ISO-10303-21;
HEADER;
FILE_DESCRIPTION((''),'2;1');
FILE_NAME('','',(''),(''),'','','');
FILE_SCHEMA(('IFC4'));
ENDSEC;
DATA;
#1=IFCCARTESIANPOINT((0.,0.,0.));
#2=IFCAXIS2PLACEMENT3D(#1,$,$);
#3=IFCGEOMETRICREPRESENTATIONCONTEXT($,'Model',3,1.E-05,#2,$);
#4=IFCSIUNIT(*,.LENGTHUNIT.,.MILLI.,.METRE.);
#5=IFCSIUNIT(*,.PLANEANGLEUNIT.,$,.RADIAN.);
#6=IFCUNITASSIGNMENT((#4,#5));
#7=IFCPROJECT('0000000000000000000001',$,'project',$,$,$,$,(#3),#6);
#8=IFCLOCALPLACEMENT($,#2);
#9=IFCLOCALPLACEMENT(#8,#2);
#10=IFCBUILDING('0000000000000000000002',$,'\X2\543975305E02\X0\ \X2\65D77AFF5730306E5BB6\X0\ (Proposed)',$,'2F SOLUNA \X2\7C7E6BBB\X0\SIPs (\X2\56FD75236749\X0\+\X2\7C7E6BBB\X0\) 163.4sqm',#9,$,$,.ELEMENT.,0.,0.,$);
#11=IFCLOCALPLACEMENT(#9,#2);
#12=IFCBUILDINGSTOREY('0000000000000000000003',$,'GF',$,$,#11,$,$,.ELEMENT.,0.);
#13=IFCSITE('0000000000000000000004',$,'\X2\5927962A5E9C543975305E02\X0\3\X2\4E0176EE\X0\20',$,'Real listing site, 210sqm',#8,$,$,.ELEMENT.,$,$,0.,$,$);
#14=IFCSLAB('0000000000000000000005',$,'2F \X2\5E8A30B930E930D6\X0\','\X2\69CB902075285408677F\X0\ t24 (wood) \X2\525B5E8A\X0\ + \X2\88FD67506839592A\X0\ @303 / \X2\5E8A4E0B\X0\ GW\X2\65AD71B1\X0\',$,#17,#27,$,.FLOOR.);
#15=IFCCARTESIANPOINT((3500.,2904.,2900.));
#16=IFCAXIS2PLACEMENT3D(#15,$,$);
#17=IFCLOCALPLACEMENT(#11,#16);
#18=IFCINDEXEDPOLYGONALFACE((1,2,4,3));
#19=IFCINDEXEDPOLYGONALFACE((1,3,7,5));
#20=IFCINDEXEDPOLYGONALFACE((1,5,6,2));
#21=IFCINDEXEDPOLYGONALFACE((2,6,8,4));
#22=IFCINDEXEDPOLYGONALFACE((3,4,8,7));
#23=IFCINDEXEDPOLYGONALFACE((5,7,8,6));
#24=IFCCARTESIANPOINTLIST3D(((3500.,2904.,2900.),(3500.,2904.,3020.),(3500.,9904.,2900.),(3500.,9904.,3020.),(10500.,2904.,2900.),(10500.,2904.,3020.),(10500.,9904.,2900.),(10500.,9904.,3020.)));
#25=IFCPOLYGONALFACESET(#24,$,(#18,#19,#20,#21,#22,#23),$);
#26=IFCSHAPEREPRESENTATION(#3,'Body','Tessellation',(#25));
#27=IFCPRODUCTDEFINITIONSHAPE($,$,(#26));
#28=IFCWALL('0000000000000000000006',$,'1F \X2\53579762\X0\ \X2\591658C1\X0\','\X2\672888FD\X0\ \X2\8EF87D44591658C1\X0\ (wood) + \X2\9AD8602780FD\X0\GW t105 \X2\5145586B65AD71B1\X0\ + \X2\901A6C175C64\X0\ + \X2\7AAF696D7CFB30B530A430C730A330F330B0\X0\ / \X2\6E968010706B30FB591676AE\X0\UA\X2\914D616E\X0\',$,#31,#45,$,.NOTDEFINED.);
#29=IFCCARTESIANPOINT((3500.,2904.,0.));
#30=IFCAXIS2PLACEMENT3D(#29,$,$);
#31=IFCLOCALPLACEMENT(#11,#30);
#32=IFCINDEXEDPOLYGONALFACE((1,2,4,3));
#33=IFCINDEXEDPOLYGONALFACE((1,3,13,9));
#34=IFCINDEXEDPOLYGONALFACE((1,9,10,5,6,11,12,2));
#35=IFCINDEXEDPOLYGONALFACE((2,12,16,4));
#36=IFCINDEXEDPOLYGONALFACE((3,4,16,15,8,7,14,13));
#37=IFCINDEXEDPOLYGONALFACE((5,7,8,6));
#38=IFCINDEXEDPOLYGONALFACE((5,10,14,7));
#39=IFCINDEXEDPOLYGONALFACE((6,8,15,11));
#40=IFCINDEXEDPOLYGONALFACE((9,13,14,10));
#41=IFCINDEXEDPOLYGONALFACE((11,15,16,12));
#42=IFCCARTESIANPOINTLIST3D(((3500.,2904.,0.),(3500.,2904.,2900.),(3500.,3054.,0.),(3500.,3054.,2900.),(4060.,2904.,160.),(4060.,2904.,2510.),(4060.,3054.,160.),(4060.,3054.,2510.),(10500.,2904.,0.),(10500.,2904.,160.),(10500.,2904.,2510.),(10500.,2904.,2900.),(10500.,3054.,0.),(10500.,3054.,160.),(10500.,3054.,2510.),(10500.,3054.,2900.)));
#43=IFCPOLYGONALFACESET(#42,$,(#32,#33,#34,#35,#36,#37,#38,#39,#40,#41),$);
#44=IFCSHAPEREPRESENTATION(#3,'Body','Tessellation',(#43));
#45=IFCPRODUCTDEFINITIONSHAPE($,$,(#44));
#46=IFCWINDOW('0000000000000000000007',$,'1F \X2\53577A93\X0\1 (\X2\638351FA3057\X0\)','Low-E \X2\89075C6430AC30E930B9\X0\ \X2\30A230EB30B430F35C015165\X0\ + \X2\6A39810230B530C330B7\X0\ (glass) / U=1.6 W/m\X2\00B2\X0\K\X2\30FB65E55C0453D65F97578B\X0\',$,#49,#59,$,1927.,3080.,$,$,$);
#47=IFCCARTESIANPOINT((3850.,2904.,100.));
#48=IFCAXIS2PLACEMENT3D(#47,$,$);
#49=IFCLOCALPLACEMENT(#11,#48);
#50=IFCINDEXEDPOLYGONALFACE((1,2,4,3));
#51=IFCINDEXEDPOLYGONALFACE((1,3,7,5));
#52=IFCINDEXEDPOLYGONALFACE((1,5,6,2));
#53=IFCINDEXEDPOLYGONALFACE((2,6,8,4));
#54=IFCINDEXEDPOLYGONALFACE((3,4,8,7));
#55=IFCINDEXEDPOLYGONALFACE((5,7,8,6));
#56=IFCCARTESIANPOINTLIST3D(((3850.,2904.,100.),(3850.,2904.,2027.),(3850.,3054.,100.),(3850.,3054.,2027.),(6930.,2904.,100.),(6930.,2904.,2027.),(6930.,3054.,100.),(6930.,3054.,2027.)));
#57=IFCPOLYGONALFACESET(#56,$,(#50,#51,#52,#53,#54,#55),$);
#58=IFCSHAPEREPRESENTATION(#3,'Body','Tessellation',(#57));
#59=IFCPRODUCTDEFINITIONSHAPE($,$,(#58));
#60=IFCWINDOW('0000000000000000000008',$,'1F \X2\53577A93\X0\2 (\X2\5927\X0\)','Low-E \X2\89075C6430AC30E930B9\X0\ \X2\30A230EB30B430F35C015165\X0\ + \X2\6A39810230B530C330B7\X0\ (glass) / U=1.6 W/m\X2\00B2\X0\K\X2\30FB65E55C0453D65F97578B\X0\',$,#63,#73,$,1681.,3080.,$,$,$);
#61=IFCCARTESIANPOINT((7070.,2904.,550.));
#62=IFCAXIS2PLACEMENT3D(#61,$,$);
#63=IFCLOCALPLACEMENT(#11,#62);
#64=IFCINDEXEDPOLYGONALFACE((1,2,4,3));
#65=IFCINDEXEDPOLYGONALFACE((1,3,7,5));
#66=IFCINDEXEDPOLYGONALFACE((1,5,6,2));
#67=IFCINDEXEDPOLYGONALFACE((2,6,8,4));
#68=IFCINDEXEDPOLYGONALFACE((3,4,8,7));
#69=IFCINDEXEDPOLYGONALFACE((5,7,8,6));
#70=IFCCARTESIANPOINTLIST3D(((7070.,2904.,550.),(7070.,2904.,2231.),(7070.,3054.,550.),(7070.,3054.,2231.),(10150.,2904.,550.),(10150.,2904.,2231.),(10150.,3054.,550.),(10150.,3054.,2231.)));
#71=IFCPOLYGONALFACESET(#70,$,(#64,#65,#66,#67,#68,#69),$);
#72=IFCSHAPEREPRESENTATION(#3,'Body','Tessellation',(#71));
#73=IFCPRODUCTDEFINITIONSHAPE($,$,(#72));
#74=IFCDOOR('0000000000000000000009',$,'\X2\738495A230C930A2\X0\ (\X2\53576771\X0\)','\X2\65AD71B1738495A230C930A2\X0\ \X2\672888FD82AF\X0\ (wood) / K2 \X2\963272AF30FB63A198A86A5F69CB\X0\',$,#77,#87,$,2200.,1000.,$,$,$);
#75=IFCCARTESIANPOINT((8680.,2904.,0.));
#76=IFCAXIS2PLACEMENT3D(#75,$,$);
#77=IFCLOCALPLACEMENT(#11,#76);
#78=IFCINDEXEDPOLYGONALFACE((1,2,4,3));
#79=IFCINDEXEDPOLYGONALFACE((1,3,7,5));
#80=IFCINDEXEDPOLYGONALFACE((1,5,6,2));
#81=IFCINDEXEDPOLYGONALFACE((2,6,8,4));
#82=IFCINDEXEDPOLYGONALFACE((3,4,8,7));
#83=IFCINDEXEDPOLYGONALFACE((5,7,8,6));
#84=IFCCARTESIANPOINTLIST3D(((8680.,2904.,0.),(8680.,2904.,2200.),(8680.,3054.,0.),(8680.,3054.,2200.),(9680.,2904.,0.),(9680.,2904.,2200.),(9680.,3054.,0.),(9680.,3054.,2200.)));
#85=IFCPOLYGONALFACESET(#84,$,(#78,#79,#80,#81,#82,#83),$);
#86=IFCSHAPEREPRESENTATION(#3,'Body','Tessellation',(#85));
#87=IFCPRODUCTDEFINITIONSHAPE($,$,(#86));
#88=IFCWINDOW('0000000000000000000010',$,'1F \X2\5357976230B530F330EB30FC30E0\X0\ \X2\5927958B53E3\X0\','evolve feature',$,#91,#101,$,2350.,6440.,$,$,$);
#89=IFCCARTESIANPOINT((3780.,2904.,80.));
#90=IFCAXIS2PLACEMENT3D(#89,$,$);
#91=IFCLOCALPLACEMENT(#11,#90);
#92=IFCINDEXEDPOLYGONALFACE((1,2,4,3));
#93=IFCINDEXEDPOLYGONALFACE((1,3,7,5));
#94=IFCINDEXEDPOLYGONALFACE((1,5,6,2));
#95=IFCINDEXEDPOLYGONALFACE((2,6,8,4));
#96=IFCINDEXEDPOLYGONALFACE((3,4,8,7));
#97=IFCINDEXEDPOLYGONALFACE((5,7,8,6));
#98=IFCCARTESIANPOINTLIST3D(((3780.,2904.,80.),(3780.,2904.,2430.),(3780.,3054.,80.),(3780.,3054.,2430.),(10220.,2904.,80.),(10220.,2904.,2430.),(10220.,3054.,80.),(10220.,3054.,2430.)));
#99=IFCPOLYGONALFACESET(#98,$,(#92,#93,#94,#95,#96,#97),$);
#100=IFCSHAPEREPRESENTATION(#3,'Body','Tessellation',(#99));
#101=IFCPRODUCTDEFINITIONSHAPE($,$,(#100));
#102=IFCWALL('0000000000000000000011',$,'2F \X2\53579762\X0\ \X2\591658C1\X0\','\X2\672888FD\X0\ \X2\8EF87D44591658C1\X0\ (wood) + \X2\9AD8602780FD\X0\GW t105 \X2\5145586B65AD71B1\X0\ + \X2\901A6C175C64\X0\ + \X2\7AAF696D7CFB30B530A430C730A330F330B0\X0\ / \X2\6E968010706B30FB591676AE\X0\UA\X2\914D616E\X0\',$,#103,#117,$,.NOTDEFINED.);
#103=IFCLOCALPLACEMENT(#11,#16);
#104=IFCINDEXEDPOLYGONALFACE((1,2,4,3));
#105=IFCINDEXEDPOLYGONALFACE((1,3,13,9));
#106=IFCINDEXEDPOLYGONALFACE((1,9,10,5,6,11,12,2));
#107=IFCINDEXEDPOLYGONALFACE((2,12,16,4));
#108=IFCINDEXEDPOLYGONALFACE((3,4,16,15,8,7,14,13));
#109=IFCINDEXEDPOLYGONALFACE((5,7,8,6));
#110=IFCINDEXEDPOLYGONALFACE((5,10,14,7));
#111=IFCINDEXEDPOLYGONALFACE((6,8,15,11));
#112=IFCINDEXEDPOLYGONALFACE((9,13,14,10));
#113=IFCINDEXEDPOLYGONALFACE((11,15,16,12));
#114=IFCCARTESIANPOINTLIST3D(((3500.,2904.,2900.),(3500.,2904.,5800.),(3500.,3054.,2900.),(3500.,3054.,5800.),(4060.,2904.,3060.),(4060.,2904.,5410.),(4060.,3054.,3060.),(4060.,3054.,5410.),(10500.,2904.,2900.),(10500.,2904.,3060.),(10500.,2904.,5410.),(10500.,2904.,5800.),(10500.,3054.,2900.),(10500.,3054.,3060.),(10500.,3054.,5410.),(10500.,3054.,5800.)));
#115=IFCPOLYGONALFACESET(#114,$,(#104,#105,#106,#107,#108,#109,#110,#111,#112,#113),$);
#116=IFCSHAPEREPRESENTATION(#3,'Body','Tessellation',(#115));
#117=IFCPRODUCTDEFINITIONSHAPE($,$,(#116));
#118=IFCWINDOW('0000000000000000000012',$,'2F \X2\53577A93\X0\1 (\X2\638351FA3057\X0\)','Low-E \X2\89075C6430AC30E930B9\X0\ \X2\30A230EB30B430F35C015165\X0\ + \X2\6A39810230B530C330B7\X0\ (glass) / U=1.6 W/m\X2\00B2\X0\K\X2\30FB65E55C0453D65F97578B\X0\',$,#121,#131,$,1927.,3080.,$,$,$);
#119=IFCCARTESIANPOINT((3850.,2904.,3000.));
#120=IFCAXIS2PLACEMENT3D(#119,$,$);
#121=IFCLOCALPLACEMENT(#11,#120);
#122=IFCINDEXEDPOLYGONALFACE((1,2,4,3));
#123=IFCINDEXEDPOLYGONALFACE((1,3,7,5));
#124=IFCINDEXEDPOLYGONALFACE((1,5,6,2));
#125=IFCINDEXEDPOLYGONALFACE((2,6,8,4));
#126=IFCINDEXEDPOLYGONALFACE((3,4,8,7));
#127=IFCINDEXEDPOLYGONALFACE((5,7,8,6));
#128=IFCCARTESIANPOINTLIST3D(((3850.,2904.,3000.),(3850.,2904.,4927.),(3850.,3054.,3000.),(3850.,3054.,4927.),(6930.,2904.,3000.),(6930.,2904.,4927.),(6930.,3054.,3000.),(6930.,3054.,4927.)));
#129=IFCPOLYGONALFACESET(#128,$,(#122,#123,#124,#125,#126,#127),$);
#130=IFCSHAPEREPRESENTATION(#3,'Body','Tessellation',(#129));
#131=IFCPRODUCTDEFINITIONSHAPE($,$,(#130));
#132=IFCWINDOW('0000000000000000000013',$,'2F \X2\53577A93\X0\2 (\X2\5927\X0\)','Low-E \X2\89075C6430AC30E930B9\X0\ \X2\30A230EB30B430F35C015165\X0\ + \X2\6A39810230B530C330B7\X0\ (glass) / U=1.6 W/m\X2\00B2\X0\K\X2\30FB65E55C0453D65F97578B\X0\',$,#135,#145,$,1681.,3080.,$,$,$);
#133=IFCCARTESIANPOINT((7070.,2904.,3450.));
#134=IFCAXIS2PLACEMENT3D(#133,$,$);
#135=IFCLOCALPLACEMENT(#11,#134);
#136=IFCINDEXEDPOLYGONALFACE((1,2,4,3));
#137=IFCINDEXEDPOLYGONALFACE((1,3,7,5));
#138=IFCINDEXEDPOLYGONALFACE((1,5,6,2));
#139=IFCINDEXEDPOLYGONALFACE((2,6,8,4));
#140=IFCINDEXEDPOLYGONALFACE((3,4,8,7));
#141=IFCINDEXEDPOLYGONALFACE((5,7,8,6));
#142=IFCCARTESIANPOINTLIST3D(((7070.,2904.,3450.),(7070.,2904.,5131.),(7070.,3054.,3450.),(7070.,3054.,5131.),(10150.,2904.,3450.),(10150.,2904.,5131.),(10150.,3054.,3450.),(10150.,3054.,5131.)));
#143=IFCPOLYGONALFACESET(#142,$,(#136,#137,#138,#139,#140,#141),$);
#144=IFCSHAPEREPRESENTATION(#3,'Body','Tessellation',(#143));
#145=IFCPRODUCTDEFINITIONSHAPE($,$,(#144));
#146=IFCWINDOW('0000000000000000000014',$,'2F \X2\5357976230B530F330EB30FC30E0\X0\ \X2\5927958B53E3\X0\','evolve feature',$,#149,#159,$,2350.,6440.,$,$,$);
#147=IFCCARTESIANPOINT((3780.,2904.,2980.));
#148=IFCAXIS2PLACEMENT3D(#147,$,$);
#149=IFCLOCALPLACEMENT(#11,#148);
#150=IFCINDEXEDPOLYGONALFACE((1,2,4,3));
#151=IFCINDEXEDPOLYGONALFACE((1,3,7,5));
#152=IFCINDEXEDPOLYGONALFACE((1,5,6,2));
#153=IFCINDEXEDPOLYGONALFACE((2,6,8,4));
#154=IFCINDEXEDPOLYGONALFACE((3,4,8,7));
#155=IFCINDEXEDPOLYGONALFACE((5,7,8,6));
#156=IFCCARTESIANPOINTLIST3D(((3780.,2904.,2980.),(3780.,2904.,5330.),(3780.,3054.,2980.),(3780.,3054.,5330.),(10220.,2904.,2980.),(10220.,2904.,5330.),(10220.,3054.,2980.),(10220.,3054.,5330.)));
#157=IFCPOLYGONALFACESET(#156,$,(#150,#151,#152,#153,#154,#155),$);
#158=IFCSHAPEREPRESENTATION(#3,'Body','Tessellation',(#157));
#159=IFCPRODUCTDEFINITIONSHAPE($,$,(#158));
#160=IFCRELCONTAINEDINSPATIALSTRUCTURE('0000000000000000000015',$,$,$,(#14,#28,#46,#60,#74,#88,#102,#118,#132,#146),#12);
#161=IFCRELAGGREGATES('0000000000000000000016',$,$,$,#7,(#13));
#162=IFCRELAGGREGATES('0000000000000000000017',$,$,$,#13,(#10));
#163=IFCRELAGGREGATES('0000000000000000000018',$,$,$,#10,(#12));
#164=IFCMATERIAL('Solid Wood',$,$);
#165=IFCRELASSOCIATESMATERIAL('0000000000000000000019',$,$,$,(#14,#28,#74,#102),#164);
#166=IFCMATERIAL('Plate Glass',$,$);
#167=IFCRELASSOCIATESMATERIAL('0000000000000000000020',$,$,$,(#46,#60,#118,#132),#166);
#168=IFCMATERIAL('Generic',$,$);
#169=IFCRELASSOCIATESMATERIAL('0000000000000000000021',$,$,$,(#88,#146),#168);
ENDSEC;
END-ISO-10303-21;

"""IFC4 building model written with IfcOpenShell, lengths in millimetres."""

from ifc_helpers import new_model, si_unit, frame, frame_2d, origin, place, context, project, spatial, rectangle, extrude, material, element, fill, save


model = new_model("IFC4")

# Units and contexts
model_context = context("Model", 3, precision=1e-05, world=origin())
ifc_project = project(units=[si_unit("LENGTHUNIT", "METRE", prefix="MILLI"), si_unit("PLANEANGLEUNIT", "RADIAN")], contexts=[model_context])

# Site, building, storey
site_placement = place(None, origin())
site = spatial("IfcSite", under=ifc_project, at=site_placement, Name="大阪府吹田市3丁目20", ObjectType="Real listing site, 210sqm", CompositionType="ELEMENT", RefElevation=0.0)
building_placement = place(site_placement, origin())
building = spatial("IfcBuilding", under=site, at=building_placement, Name="吹田市 旗竿地の家 (Proposed)", ObjectType="2F SOLUNA 籾殻SIPs (国産杉+籾殻) 163.4sqm", CompositionType="ELEMENT", ElevationOfRefHeight=0.0, ElevationOfTerrain=0.0)
storey_placement = place(building_placement, origin())
storey = spatial("IfcBuildingStorey", under=building, at=storey_placement, Name="GF", CompositionType="ELEMENT", Elevation=0.0)

# Slab
ifc_material_1 = material(Name="Solid Wood")
slab_1_placement = place(storey_placement, frame((3500.0, 2904.0, 2900.0)))
element("IfcSlab", 1, at=slab_1_placement, inside=storey, material=ifc_material_1, Name="2F 床スラブ", Description="構造用合板 t24 (wood) 剛床 + 製材根太 @303 / 床下 GW断熱", PredefinedType="FLOOR", context=model_context, shape_type="SweptSolid", body=[
    extrude(rectangle(XDim=7000.0, YDim=7000.0, at=frame_2d((3500.0, 3500.0))), frame((3500.0, 2904.0, 2900.0)), (0.0, 0.0, 1.0), 120.0),
])
ifc_material_2 = material(Name="Generic")

# Wall, openings, windows, door
wall_1_placement = place(storey_placement, frame((3500.0, 2904.0, 0.0)))
wall_1 = element("IfcWall", 2, at=wall_1_placement, inside=storey, material=ifc_material_1, Name="1F 南面 外壁", Description="木製 軸組外壁 (wood) + 高性能GW t105 充填断熱 + 通気層 + 窯業系サイディング / 準耐火・外皮UA配慮", PredefinedType="NOTDEFINED", context=model_context, shape_type="SweptSolid", body=[
    extrude(rectangle(XDim=7000.0, YDim=150.0, at=frame_2d((3500.0, 75.0))), frame((3500.0, 2904.0, 0.0)), (0.0, 0.0, 1.0), 2900.0),
])
opening_1_placement = place(storey_placement, frame((3850.0, 2904.0, 100.0)))
opening_1 = element("IfcOpeningElement", 3, at=opening_1_placement, cuts=wall_1, PredefinedType="NOTDEFINED", context=model_context, shape_type="SweptSolid", body=[
    extrude(rectangle(XDim=3080.0, YDim=150.0, at=frame_2d((1540.0, 75.0))), frame((3850.0, 2904.0, 100.0)), (0.0, 0.0, 1.0), 1927.0),
])
opening_2_placement = place(storey_placement, frame((7070.0, 2904.0, 550.0)))
opening_2 = element("IfcOpeningElement", 4, at=opening_2_placement, cuts=wall_1, PredefinedType="NOTDEFINED", context=model_context, shape_type="SweptSolid", body=[
    extrude(rectangle(XDim=3080.0, YDim=150.0, at=frame_2d((1540.0, 75.0))), frame((7070.0, 2904.0, 550.0)), (0.0, 0.0, 1.0), 1681.0),
])
opening_3_placement = place(storey_placement, frame((8680.0, 2904.0, 0.0)))
opening_3 = element("IfcOpeningElement", 5, at=opening_3_placement, cuts=wall_1, PredefinedType="NOTDEFINED", context=model_context, shape_type="SweptSolid", body=[
    extrude(rectangle(XDim=1000.0, YDim=150.0, at=frame_2d((500.0, 75.0))), frame((8680.0, 2904.0, 0.0)), (0.0, 0.0, 1.0), 2200.0),
])
opening_4_placement = place(storey_placement, frame((3780.0, 2904.0, 80.0)))
opening_4 = element("IfcOpeningElement", 6, at=opening_4_placement, cuts=wall_1, PredefinedType="NOTDEFINED", context=model_context, shape_type="SweptSolid", body=[
    extrude(rectangle(XDim=6440.0, YDim=150.0, at=frame_2d((3220.0, 75.0))), frame((3780.0, 2904.0, 80.0)), (0.0, 0.0, 1.0), 2350.0),
])
ifc_material_3 = material(Name="Plate Glass")
window_1_placement = place(storey_placement, frame((3850.0, 2904.0, 100.0)))
window_1 = element("IfcWindow", 7, at=window_1_placement, inside=storey, material=ifc_material_3, Name="1F 南窓1 (掃出し)", Description="Low-E 複層ガラス アルゴン封入 + 樹脂サッシ (glass) / U=1.6 W/m²K・日射取得型", OverallHeight=1927.0, OverallWidth=3080.0, context=model_context, shape_type="SweptSolid", body=[
    extrude(rectangle(XDim=3080.0, YDim=150.0, at=frame_2d((1540.0, 75.0))), frame((3850.0, 2904.0, 100.0)), (0.0, 0.0, 1.0), 1927.0),
])
fill(opening_1, window_1)
window_2_placement = place(storey_placement, frame((7070.0, 2904.0, 550.0)))
window_2 = element("IfcWindow", 8, at=window_2_placement, inside=storey, material=ifc_material_3, Name="1F 南窓2 (大)", Description="Low-E 複層ガラス アルゴン封入 + 樹脂サッシ (glass) / U=1.6 W/m²K・日射取得型", OverallHeight=1681.0, OverallWidth=3080.0, context=model_context, shape_type="SweptSolid", body=[
    extrude(rectangle(XDim=3080.0, YDim=150.0, at=frame_2d((1540.0, 75.0))), frame((7070.0, 2904.0, 550.0)), (0.0, 0.0, 1.0), 1681.0),
])
fill(opening_2, window_2)
door_placement = place(storey_placement, frame((8680.0, 2904.0, 0.0)))
door = element("IfcDoor", 9, at=door_placement, inside=storey, material=ifc_material_1, Name="玄関ドア (南東)", Description="断熱玄関ドア 木製芯 (wood) / K2 防犯・採風機構", OverallHeight=2200.0, OverallWidth=1000.0, context=model_context, shape_type="SweptSolid", body=[
    extrude(rectangle(XDim=1000.0, YDim=150.0, at=frame_2d((500.0, 75.0))), frame((8680.0, 2904.0, 0.0)), (0.0, 0.0, 1.0), 2200.0),
])
fill(opening_3, door)
window_3_placement = place(storey_placement, frame((3780.0, 2904.0, 80.0)))
window_3 = element("IfcWindow", 10, at=window_3_placement, inside=storey, material=ifc_material_2, Name="1F 南面サンルーム 大開口", Description="evolve feature", OverallHeight=2350.0, OverallWidth=6440.0, context=model_context, shape_type="SweptSolid", body=[
    extrude(rectangle(XDim=6440.0, YDim=150.0, at=frame_2d((3220.0, 75.0))), frame((3780.0, 2904.0, 80.0)), (0.0, 0.0, 1.0), 2350.0),
])
fill(opening_4, window_3)

# Wall, openings, windows
wall_2_placement = place(storey_placement, frame((3500.0, 2904.0, 2900.0)))
wall_2 = element("IfcWall", 11, at=wall_2_placement, inside=storey, material=ifc_material_1, Name="2F 南面 外壁", Description="木製 軸組外壁 (wood) + 高性能GW t105 充填断熱 + 通気層 + 窯業系サイディング / 準耐火・外皮UA配慮", PredefinedType="NOTDEFINED", context=model_context, shape_type="SweptSolid", body=[
    extrude(rectangle(XDim=7000.0, YDim=150.0, at=frame_2d((3500.0, 75.0))), frame((3500.0, 2904.0, 2900.0)), (0.0, 0.0, 1.0), 2900.0),
])
opening_5_placement = place(storey_placement, frame((3850.0, 2904.0, 3000.0)))
opening_5 = element("IfcOpeningElement", 12, at=opening_5_placement, cuts=wall_2, PredefinedType="NOTDEFINED", context=model_context, shape_type="SweptSolid", body=[
    extrude(rectangle(XDim=3080.0, YDim=150.0, at=frame_2d((1540.0, 75.0))), frame((3850.0, 2904.0, 3000.0)), (0.0, 0.0, 1.0), 1927.0),
])
opening_6_placement = place(storey_placement, frame((7070.0, 2904.0, 3450.0)))
opening_6 = element("IfcOpeningElement", 13, at=opening_6_placement, cuts=wall_2, PredefinedType="NOTDEFINED", context=model_context, shape_type="SweptSolid", body=[
    extrude(rectangle(XDim=3080.0, YDim=150.0, at=frame_2d((1540.0, 75.0))), frame((7070.0, 2904.0, 3450.0)), (0.0, 0.0, 1.0), 1681.0),
])
opening_7_placement = place(storey_placement, frame((3780.0, 2904.0, 2980.0)))
opening_7 = element("IfcOpeningElement", 14, at=opening_7_placement, cuts=wall_2, PredefinedType="NOTDEFINED", context=model_context, shape_type="SweptSolid", body=[
    extrude(rectangle(XDim=6440.0, YDim=150.0, at=frame_2d((3220.0, 75.0))), frame((3780.0, 2904.0, 2980.0)), (0.0, 0.0, 1.0), 2350.0),
])
window_4_placement = place(storey_placement, frame((3850.0, 2904.0, 3000.0)))
window_4 = element("IfcWindow", 15, at=window_4_placement, inside=storey, material=ifc_material_3, Name="2F 南窓1 (掃出し)", Description="Low-E 複層ガラス アルゴン封入 + 樹脂サッシ (glass) / U=1.6 W/m²K・日射取得型", OverallHeight=1927.0, OverallWidth=3080.0, context=model_context, shape_type="SweptSolid", body=[
    extrude(rectangle(XDim=3080.0, YDim=150.0, at=frame_2d((1540.0, 75.0))), frame((3850.0, 2904.0, 3000.0)), (0.0, 0.0, 1.0), 1927.0),
])
fill(opening_5, window_4)
window_5_placement = place(storey_placement, frame((7070.0, 2904.0, 3450.0)))
window_5 = element("IfcWindow", 16, at=window_5_placement, inside=storey, material=ifc_material_3, Name="2F 南窓2 (大)", Description="Low-E 複層ガラス アルゴン封入 + 樹脂サッシ (glass) / U=1.6 W/m²K・日射取得型", OverallHeight=1681.0, OverallWidth=3080.0, context=model_context, shape_type="SweptSolid", body=[
    extrude(rectangle(XDim=3080.0, YDim=150.0, at=frame_2d((1540.0, 75.0))), frame((7070.0, 2904.0, 3450.0)), (0.0, 0.0, 1.0), 1681.0),
])
fill(opening_6, window_5)
window_6_placement = place(storey_placement, frame((3780.0, 2904.0, 2980.0)))
window_6 = element("IfcWindow", 17, at=window_6_placement, inside=storey, material=ifc_material_2, Name="2F 南面サンルーム 大開口", Description="evolve feature", OverallHeight=2350.0, OverallWidth=6440.0, context=model_context, shape_type="SweptSolid", body=[
    extrude(rectangle(XDim=6440.0, YDim=150.0, at=frame_2d((3220.0, 75.0))), frame((3780.0, 2904.0, 2980.0)), (0.0, 0.0, 1.0), 2350.0),
])
fill(opening_7, window_6)

save(model, "model.ifc")
